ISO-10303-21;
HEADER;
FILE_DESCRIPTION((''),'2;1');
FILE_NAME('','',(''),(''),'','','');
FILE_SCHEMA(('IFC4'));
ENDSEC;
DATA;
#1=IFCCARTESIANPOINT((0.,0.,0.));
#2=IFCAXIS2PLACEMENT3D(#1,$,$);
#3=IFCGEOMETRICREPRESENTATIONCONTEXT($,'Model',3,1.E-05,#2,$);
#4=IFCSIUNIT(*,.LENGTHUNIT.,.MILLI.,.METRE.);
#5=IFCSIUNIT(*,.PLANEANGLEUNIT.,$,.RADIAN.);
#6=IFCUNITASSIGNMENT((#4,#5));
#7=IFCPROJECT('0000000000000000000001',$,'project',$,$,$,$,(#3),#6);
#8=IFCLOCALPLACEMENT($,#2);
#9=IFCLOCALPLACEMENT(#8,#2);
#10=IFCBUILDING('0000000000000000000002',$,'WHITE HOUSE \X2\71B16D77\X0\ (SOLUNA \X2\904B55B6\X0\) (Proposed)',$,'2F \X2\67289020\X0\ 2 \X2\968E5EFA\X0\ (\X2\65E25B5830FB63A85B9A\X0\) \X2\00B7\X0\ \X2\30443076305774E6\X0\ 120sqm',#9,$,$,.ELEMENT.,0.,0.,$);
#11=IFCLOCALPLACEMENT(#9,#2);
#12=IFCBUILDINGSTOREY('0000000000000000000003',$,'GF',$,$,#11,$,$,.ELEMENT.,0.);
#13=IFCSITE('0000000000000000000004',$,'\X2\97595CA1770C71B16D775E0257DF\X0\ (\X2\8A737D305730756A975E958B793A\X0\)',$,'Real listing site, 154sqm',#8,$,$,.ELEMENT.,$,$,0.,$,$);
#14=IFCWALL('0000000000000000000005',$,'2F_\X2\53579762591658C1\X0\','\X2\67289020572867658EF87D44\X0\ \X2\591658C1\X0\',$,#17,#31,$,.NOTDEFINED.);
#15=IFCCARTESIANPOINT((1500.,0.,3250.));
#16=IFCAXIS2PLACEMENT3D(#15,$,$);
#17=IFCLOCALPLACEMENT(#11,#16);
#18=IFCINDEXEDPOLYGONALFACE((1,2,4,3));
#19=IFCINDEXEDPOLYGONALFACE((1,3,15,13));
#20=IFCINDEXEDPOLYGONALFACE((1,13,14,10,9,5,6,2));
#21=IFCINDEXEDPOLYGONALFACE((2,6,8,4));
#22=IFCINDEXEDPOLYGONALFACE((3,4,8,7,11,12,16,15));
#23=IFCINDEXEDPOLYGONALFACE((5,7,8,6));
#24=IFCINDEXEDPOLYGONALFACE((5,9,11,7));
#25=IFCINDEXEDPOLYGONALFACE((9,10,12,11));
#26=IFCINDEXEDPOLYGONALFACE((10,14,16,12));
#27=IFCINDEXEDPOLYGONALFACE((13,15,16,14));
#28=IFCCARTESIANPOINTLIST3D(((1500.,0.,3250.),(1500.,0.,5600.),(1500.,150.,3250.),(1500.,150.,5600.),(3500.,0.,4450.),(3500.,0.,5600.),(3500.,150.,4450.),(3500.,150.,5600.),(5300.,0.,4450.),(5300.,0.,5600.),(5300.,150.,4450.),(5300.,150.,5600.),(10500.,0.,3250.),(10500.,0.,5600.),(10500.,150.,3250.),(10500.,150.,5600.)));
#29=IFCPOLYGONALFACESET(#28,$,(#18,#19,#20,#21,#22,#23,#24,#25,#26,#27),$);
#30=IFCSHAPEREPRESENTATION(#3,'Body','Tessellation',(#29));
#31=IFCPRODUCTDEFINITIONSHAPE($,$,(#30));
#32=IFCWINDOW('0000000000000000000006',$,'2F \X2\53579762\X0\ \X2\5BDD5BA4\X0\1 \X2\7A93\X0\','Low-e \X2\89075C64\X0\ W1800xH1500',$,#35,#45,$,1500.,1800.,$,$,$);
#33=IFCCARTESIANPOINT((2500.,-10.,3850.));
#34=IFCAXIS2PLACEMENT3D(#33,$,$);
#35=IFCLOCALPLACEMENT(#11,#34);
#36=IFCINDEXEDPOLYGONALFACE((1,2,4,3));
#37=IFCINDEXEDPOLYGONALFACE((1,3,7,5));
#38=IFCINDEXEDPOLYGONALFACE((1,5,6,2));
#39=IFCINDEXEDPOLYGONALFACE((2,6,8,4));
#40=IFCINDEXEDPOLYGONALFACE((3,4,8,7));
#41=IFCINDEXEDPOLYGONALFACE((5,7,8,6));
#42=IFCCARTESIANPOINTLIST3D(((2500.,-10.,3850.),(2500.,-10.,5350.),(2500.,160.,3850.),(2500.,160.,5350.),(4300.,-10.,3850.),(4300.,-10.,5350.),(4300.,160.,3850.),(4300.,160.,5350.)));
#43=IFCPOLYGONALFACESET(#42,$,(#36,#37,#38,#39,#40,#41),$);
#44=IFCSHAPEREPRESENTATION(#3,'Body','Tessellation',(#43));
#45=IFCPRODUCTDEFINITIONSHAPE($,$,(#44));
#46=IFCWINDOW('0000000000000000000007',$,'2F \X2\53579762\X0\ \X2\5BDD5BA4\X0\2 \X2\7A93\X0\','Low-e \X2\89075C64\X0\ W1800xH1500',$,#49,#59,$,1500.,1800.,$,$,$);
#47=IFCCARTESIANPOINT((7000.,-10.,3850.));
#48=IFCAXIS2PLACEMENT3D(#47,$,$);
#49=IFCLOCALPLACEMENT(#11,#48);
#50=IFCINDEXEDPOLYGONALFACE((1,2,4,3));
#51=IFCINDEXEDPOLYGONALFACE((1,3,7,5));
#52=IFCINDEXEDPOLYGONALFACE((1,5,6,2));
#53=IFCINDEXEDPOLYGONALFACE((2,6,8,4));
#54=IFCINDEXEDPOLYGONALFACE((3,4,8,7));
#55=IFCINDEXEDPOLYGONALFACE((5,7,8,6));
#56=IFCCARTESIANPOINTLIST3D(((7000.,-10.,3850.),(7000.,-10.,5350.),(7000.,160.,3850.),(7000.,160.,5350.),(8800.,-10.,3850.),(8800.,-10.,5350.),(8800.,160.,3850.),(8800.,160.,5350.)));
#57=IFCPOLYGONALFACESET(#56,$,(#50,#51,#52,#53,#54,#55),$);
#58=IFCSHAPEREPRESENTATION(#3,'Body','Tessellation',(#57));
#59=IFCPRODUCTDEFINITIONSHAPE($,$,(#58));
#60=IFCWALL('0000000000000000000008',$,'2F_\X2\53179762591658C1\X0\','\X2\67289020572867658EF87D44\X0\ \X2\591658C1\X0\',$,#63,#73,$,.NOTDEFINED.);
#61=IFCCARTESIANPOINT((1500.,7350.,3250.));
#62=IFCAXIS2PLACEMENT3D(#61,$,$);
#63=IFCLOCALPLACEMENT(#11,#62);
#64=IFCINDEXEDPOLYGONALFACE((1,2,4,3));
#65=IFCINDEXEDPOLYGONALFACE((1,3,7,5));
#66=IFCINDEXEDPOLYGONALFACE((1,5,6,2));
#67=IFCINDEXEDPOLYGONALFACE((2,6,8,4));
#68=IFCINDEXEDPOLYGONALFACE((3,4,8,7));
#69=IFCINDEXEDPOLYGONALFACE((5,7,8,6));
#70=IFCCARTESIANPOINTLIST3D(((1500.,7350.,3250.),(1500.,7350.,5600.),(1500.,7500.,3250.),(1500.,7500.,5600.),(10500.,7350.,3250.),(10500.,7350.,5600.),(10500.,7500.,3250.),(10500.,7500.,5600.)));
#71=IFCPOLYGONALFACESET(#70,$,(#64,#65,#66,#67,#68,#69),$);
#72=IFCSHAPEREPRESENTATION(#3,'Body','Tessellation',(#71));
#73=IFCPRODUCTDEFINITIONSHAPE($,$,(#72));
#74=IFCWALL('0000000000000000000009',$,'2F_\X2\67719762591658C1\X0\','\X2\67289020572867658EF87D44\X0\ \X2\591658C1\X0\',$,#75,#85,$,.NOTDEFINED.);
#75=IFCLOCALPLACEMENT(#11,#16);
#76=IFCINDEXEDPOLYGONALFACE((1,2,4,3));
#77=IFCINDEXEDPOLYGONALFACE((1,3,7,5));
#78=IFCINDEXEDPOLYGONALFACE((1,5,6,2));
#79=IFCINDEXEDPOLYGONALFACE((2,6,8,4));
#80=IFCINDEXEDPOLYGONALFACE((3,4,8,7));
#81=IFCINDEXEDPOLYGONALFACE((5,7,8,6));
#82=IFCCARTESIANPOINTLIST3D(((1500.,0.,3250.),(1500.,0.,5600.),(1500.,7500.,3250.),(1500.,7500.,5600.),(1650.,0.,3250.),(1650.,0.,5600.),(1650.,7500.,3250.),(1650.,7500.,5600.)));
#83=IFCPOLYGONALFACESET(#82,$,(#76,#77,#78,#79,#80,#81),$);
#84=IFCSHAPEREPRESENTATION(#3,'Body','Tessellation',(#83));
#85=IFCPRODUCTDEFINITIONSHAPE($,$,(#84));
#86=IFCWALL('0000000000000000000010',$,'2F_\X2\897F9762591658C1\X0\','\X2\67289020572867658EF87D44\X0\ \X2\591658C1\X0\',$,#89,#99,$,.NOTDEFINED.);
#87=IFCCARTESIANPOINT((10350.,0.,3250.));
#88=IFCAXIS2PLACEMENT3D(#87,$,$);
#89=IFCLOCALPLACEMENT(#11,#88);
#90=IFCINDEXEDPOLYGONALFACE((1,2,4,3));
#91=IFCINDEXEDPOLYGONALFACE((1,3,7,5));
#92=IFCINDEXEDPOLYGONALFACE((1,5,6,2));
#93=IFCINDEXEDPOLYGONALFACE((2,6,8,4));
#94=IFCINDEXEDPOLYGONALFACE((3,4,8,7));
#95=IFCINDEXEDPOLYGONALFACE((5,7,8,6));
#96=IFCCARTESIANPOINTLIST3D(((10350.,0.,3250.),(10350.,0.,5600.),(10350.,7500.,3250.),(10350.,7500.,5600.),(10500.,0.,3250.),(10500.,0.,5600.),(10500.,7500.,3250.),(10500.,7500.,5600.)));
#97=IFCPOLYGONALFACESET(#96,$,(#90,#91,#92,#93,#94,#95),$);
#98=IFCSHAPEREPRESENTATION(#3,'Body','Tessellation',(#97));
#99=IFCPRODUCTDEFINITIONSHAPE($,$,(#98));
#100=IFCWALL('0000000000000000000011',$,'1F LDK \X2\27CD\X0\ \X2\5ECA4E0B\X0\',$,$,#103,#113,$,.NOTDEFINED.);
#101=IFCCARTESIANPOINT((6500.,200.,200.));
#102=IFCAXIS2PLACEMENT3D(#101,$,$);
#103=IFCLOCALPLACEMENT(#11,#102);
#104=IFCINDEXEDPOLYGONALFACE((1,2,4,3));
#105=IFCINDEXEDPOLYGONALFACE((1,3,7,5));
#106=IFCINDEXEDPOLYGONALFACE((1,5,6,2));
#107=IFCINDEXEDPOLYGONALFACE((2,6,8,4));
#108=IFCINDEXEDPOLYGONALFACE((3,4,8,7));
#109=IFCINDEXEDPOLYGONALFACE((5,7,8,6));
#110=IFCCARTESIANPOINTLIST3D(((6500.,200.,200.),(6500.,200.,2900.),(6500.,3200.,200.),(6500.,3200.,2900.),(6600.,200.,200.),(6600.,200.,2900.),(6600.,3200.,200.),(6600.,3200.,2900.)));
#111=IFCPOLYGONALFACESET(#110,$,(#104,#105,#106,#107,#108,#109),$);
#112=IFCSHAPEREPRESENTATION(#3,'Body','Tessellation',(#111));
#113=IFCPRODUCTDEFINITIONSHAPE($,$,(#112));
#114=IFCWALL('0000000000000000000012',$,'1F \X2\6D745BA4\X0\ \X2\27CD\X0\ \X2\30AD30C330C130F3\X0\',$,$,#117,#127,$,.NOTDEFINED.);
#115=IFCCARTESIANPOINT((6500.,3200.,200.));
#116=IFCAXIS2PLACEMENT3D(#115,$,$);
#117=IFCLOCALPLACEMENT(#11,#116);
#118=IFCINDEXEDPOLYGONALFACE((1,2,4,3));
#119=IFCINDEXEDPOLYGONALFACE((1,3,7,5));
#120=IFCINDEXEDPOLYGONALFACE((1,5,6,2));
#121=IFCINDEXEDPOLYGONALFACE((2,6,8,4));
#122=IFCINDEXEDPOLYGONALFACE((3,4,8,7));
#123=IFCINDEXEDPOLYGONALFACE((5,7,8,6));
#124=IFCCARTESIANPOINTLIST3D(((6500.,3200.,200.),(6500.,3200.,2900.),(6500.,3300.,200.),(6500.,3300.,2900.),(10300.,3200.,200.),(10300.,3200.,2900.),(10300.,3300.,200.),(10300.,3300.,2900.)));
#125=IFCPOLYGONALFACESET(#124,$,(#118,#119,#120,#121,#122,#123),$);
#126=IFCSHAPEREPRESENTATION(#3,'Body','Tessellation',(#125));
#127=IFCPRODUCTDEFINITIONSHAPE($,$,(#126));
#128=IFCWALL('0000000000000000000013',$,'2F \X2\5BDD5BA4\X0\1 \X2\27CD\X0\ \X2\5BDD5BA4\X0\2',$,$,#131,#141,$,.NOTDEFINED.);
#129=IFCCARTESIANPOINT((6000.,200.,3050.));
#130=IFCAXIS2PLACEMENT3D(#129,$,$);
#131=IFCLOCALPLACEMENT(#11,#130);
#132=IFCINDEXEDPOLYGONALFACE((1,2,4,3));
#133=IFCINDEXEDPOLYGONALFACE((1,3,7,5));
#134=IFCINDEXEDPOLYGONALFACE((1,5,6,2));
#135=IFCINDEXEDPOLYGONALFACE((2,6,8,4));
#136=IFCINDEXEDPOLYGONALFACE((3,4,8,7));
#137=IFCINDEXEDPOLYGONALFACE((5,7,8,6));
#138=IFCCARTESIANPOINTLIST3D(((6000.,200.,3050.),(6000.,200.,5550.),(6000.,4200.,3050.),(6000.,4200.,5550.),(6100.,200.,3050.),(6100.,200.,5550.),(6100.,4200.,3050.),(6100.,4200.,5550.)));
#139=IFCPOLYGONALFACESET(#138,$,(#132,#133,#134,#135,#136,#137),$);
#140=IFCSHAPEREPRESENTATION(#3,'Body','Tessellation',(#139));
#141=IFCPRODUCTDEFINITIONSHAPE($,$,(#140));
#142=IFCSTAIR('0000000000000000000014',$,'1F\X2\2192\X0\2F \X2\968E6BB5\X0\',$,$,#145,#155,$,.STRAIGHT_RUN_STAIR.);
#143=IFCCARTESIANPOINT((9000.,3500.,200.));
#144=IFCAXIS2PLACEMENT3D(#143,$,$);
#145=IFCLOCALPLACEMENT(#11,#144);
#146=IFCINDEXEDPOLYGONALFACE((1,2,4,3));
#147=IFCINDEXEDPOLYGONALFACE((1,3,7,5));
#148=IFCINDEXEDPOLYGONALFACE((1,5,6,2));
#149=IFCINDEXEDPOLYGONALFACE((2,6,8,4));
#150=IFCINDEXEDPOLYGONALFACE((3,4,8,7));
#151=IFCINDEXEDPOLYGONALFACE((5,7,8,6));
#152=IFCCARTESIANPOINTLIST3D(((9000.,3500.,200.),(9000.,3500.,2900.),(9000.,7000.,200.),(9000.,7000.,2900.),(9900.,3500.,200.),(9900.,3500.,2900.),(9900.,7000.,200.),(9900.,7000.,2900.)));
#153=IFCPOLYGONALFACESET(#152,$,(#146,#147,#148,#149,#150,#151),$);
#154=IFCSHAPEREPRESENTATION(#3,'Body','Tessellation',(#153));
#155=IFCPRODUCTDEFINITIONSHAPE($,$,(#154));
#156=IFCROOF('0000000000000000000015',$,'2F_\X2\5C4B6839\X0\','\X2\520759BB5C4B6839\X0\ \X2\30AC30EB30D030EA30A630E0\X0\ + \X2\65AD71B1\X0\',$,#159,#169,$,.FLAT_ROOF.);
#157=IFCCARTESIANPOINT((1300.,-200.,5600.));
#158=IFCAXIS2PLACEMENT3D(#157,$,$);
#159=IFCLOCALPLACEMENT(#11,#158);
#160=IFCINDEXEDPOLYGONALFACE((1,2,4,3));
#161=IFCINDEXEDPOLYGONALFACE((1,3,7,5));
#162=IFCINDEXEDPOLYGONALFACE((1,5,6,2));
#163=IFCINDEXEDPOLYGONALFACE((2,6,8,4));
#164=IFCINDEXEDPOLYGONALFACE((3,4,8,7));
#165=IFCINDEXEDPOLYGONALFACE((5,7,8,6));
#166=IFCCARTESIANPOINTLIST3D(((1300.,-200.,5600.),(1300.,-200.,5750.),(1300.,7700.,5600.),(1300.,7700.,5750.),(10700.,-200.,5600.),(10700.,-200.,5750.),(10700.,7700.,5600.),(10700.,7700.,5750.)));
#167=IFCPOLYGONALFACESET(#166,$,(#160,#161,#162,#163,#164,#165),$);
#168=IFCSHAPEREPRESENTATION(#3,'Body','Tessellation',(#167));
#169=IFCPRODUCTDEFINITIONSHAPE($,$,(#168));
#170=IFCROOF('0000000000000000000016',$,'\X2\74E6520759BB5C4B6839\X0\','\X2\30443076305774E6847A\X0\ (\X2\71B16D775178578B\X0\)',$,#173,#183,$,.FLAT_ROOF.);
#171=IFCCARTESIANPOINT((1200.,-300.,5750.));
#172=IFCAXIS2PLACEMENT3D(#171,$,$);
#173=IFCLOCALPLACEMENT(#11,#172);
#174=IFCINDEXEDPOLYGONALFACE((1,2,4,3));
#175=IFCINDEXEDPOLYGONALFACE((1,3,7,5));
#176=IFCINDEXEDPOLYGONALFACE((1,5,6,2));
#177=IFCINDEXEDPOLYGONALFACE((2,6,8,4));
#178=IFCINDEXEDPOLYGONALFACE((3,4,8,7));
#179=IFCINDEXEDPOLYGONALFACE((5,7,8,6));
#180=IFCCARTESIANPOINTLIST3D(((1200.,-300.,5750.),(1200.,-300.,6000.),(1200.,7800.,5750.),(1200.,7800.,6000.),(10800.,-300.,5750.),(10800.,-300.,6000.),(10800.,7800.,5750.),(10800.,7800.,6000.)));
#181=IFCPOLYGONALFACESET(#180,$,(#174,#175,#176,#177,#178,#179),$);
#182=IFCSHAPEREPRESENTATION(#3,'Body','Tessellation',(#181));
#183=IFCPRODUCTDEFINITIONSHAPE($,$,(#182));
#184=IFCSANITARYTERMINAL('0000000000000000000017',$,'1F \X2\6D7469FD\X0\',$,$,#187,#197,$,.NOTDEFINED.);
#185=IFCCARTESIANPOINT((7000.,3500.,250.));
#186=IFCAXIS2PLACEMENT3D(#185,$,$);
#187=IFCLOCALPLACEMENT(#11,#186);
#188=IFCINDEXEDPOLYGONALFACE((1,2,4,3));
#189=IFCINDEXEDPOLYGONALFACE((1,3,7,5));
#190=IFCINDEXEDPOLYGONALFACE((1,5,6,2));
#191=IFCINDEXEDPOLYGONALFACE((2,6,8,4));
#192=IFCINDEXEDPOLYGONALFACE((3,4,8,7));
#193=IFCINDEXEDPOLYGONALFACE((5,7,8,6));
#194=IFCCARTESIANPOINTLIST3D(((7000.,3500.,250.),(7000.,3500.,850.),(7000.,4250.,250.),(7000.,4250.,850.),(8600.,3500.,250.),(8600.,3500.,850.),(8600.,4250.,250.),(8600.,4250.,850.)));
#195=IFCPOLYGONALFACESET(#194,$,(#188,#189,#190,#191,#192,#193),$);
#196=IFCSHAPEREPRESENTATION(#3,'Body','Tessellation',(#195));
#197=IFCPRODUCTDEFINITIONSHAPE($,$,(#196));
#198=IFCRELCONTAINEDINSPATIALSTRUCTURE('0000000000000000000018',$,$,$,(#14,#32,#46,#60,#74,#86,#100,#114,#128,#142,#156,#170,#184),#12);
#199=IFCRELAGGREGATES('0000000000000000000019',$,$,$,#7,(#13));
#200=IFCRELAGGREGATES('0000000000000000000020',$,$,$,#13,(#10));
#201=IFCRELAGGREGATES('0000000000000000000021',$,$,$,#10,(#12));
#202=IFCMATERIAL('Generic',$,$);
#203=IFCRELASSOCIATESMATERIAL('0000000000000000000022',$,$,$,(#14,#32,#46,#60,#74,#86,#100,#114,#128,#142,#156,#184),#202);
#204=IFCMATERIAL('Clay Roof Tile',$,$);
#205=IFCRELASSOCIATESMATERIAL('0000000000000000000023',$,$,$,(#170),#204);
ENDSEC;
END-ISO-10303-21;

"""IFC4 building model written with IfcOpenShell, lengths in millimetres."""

from ifc_helpers import new_model, si_unit, frame, frame_2d, origin, place, context, project, spatial, rectangle, extrude, material, element, fill, save


model = new_model("IFC4")

# Units and contexts
model_context = context("Model", 3, precision=1e-05, world=origin())
ifc_project = project(units=[si_unit("LENGTHUNIT", "METRE", prefix="MILLI"), si_unit("PLANEANGLEUNIT", "RADIAN")], contexts=[model_context])

# Site, building, storey
site_placement = place(None, origin())
site = spatial("IfcSite", under=ifc_project, at=site_placement, Name="静岡県熱海市域 (詳細地番非開示)", ObjectType="Real listing site, 154sqm", CompositionType="ELEMENT", RefElevation=0.0)
building_placement = place(site_placement, origin())
building = spatial("IfcBuilding", under=site, at=building_placement, Name="WHITE HOUSE 熱海 (SOLUNA 運営) (Proposed)", ObjectType="2F 木造 2 階建 (既存・推定) · いぶし瓦 120sqm", CompositionType="ELEMENT", ElevationOfRefHeight=0.0, ElevationOfTerrain=0.0)
storey_placement = place(building_placement, origin())
storey = spatial("IfcBuildingStorey", under=building, at=storey_placement, Name="GF", CompositionType="ELEMENT", Elevation=0.0)

# Shared definitions
ifc_material_1 = material(Name="Generic")

# Wall, openings, windows
wall_1_placement = place(storey_placement, frame((1500.0, 0.0, 3250.0)))
wall_1 = element("IfcWall", 1, at=wall_1_placement, inside=storey, material=ifc_material_1, Name="2F_南面外壁", Description="木造在来軸組 外壁", PredefinedType="NOTDEFINED", context=model_context, shape_type="SweptSolid", body=[
    extrude(rectangle(XDim=9000.0, YDim=150.0, at=frame_2d((4500.0, 75.0))), frame((1500.0, 0.0, 3250.0)), (0.0, 0.0, 1.0), 2350.0),
])
opening_1_placement = place(storey_placement, frame((2500.0, -10.0, 3850.0)))
opening_1 = element("IfcOpeningElement", 2, at=opening_1_placement, cuts=wall_1, PredefinedType="NOTDEFINED", context=model_context, shape_type="SweptSolid", body=[
    extrude(rectangle(XDim=1800.0, YDim=170.0, at=frame_2d((900.0, 85.0))), frame((2500.0, -10.0, 3850.0)), (0.0, 0.0, 1.0), 1500.0),
])
opening_2_placement = place(storey_placement, frame((7000.0, -10.0, 3850.0)))
opening_2 = element("IfcOpeningElement", 3, at=opening_2_placement, cuts=wall_1, PredefinedType="NOTDEFINED", context=model_context, shape_type="SweptSolid", body=[
    extrude(rectangle(XDim=1800.0, YDim=170.0, at=frame_2d((900.0, 85.0))), frame((7000.0, -10.0, 3850.0)), (0.0, 0.0, 1.0), 1500.0),
])
window_1_placement = place(storey_placement, frame((2500.0, -10.0, 3850.0)))
window_1 = element("IfcWindow", 4, at=window_1_placement, inside=storey, material=ifc_material_1, Name="2F 南面 寝室1 窓", Description="Low-e 複層 W1800xH1500", OverallHeight=1500.0, OverallWidth=1800.0, context=model_context, shape_type="SweptSolid", body=[
    extrude(rectangle(XDim=1800.0, YDim=170.0, at=frame_2d((900.0, 85.0))), frame((2500.0, -10.0, 3850.0)), (0.0, 0.0, 1.0), 1500.0),
])
fill(opening_1, window_1)
window_2_placement = place(storey_placement, frame((7000.0, -10.0, 3850.0)))
window_2 = element("IfcWindow", 5, at=window_2_placement, inside=storey, material=ifc_material_1, Name="2F 南面 寝室2 窓", Description="Low-e 複層 W1800xH1500", OverallHeight=1500.0, OverallWidth=1800.0, context=model_context, shape_type="SweptSolid", body=[
    extrude(rectangle(XDim=1800.0, YDim=170.0, at=frame_2d((900.0, 85.0))), frame((7000.0, -10.0, 3850.0)), (0.0, 0.0, 1.0), 1500.0),
])
fill(opening_2, window_2)

# Walls
wall_2_placement = place(storey_placement, frame((1500.0, 7350.0, 3250.0)))
element("IfcWall", 6, at=wall_2_placement, inside=storey, material=ifc_material_1, Name="2F_北面外壁", Description="木造在来軸組 外壁", PredefinedType="NOTDEFINED", context=model_context, shape_type="SweptSolid", body=[
    extrude(rectangle(XDim=9000.0, YDim=150.0, at=frame_2d((4500.0, 75.0))), frame((1500.0, 7350.0, 3250.0)), (0.0, 0.0, 1.0), 2350.0),
])
wall_3_placement = place(storey_placement, frame((1500.0, 0.0, 3250.0)))
element("IfcWall", 7, at=wall_3_placement, inside=storey, material=ifc_material_1, Name="2F_東面外壁", Description="木造在来軸組 外壁", PredefinedType="NOTDEFINED", context=model_context, shape_type="SweptSolid", body=[
    extrude(rectangle(XDim=150.0, YDim=7500.0, at=frame_2d((75.0, 3750.0))), frame((1500.0, 0.0, 3250.0)), (0.0, 0.0, 1.0), 2350.0),
])
wall_4_placement = place(storey_placement, frame((10350.0, 0.0, 3250.0)))
element("IfcWall", 8, at=wall_4_placement, inside=storey, material=ifc_material_1, Name="2F_西面外壁", Description="木造在来軸組 外壁", PredefinedType="NOTDEFINED", context=model_context, shape_type="SweptSolid", body=[
    extrude(rectangle(XDim=150.0, YDim=7500.0, at=frame_2d((75.0, 3750.0))), frame((10350.0, 0.0, 3250.0)), (0.0, 0.0, 1.0), 2350.0),
])
wall_5_placement = place(storey_placement, frame((6500.0, 200.0, 200.0)))
element("IfcWall", 9, at=wall_5_placement, inside=storey, material=ifc_material_1, Name="1F LDK ⟍ 廊下", PredefinedType="NOTDEFINED", context=model_context, shape_type="SweptSolid", body=[
    extrude(rectangle(XDim=100.0, YDim=3000.0, at=frame_2d((50.0, 1500.0))), frame((6500.0, 200.0, 200.0)), (0.0, 0.0, 1.0), 2700.0),
])
wall_6_placement = place(storey_placement, frame((6500.0, 3200.0, 200.0)))
element("IfcWall", 10, at=wall_6_placement, inside=storey, material=ifc_material_1, Name="1F 浴室 ⟍ キッチン", PredefinedType="NOTDEFINED", context=model_context, shape_type="SweptSolid", body=[
    extrude(rectangle(XDim=3800.0, YDim=100.0, at=frame_2d((1900.0, 50.0))), frame((6500.0, 3200.0, 200.0)), (0.0, 0.0, 1.0), 2700.0),
])
wall_7_placement = place(storey_placement, frame((6000.0, 200.0, 3050.0)))
element("IfcWall", 11, at=wall_7_placement, inside=storey, material=ifc_material_1, Name="2F 寝室1 ⟍ 寝室2", PredefinedType="NOTDEFINED", context=model_context, shape_type="SweptSolid", body=[
    extrude(rectangle(XDim=100.0, YDim=4000.0, at=frame_2d((50.0, 2000.0))), frame((6000.0, 200.0, 3050.0)), (0.0, 0.0, 1.0), 2500.0),
])

# Stair
stair_placement = place(storey_placement, frame((9000.0, 3500.0, 200.0)))
element("IfcStair", 12, at=stair_placement, inside=storey, material=ifc_material_1, Name="1F→2F 階段", PredefinedType="STRAIGHT_RUN_STAIR", context=model_context, shape_type="SweptSolid", body=[
    extrude(rectangle(XDim=900.0, YDim=3500.0, at=frame_2d((450.0, 1750.0))), frame((9000.0, 3500.0, 200.0)), (0.0, 0.0, 1.0), 2700.0),
])

# Roofs
roof_1_placement = place(storey_placement, frame((1300.0, -200.0, 5600.0)))
element("IfcRoof", 13, at=roof_1_placement, inside=storey, material=ifc_material_1, Name="2F_屋根", Description="切妻屋根 ガルバリウム + 断熱", PredefinedType="FLAT_ROOF", context=model_context, shape_type="SweptSolid", body=[
    extrude(rectangle(XDim=9400.0, YDim=7900.0, at=frame_2d((4700.0, 3950.0))), frame((1300.0, -200.0, 5600.0)), (0.0, 0.0, 1.0), 150.0),
])
ifc_material_2 = material(Name="Clay Roof Tile")
roof_2_placement = place(storey_placement, frame((1200.0, -300.0, 5750.0)))
element("IfcRoof", 14, at=roof_2_placement, inside=storey, material=ifc_material_2, Name="瓦切妻屋根", Description="いぶし瓦葺 (熱海典型)", PredefinedType="FLAT_ROOF", context=model_context, shape_type="SweptSolid", body=[
    extrude(rectangle(XDim=9600.0, YDim=8100.0, at=frame_2d((4800.0, 4050.0))), frame((1200.0, -300.0, 5750.0)), (0.0, 0.0, 1.0), 250.0),
])

# Sanitary terminal
sanitary_terminal_1_placement = place(storey_placement, frame((7000.0, 3500.0, 250.0)))
element("IfcSanitaryTerminal", 15, at=sanitary_terminal_1_placement, inside=storey, material=ifc_material_1, Name="1F 浴槽", PredefinedType="NOTDEFINED", context=model_context, shape_type="SweptSolid", body=[
    extrude(rectangle(XDim=1600.0, YDim=750.0, at=frame_2d((800.0, 375.0))), frame((7000.0, 3500.0, 250.0)), (0.0, 0.0, 1.0), 600.0),
])

save(model, "model.ifc")
